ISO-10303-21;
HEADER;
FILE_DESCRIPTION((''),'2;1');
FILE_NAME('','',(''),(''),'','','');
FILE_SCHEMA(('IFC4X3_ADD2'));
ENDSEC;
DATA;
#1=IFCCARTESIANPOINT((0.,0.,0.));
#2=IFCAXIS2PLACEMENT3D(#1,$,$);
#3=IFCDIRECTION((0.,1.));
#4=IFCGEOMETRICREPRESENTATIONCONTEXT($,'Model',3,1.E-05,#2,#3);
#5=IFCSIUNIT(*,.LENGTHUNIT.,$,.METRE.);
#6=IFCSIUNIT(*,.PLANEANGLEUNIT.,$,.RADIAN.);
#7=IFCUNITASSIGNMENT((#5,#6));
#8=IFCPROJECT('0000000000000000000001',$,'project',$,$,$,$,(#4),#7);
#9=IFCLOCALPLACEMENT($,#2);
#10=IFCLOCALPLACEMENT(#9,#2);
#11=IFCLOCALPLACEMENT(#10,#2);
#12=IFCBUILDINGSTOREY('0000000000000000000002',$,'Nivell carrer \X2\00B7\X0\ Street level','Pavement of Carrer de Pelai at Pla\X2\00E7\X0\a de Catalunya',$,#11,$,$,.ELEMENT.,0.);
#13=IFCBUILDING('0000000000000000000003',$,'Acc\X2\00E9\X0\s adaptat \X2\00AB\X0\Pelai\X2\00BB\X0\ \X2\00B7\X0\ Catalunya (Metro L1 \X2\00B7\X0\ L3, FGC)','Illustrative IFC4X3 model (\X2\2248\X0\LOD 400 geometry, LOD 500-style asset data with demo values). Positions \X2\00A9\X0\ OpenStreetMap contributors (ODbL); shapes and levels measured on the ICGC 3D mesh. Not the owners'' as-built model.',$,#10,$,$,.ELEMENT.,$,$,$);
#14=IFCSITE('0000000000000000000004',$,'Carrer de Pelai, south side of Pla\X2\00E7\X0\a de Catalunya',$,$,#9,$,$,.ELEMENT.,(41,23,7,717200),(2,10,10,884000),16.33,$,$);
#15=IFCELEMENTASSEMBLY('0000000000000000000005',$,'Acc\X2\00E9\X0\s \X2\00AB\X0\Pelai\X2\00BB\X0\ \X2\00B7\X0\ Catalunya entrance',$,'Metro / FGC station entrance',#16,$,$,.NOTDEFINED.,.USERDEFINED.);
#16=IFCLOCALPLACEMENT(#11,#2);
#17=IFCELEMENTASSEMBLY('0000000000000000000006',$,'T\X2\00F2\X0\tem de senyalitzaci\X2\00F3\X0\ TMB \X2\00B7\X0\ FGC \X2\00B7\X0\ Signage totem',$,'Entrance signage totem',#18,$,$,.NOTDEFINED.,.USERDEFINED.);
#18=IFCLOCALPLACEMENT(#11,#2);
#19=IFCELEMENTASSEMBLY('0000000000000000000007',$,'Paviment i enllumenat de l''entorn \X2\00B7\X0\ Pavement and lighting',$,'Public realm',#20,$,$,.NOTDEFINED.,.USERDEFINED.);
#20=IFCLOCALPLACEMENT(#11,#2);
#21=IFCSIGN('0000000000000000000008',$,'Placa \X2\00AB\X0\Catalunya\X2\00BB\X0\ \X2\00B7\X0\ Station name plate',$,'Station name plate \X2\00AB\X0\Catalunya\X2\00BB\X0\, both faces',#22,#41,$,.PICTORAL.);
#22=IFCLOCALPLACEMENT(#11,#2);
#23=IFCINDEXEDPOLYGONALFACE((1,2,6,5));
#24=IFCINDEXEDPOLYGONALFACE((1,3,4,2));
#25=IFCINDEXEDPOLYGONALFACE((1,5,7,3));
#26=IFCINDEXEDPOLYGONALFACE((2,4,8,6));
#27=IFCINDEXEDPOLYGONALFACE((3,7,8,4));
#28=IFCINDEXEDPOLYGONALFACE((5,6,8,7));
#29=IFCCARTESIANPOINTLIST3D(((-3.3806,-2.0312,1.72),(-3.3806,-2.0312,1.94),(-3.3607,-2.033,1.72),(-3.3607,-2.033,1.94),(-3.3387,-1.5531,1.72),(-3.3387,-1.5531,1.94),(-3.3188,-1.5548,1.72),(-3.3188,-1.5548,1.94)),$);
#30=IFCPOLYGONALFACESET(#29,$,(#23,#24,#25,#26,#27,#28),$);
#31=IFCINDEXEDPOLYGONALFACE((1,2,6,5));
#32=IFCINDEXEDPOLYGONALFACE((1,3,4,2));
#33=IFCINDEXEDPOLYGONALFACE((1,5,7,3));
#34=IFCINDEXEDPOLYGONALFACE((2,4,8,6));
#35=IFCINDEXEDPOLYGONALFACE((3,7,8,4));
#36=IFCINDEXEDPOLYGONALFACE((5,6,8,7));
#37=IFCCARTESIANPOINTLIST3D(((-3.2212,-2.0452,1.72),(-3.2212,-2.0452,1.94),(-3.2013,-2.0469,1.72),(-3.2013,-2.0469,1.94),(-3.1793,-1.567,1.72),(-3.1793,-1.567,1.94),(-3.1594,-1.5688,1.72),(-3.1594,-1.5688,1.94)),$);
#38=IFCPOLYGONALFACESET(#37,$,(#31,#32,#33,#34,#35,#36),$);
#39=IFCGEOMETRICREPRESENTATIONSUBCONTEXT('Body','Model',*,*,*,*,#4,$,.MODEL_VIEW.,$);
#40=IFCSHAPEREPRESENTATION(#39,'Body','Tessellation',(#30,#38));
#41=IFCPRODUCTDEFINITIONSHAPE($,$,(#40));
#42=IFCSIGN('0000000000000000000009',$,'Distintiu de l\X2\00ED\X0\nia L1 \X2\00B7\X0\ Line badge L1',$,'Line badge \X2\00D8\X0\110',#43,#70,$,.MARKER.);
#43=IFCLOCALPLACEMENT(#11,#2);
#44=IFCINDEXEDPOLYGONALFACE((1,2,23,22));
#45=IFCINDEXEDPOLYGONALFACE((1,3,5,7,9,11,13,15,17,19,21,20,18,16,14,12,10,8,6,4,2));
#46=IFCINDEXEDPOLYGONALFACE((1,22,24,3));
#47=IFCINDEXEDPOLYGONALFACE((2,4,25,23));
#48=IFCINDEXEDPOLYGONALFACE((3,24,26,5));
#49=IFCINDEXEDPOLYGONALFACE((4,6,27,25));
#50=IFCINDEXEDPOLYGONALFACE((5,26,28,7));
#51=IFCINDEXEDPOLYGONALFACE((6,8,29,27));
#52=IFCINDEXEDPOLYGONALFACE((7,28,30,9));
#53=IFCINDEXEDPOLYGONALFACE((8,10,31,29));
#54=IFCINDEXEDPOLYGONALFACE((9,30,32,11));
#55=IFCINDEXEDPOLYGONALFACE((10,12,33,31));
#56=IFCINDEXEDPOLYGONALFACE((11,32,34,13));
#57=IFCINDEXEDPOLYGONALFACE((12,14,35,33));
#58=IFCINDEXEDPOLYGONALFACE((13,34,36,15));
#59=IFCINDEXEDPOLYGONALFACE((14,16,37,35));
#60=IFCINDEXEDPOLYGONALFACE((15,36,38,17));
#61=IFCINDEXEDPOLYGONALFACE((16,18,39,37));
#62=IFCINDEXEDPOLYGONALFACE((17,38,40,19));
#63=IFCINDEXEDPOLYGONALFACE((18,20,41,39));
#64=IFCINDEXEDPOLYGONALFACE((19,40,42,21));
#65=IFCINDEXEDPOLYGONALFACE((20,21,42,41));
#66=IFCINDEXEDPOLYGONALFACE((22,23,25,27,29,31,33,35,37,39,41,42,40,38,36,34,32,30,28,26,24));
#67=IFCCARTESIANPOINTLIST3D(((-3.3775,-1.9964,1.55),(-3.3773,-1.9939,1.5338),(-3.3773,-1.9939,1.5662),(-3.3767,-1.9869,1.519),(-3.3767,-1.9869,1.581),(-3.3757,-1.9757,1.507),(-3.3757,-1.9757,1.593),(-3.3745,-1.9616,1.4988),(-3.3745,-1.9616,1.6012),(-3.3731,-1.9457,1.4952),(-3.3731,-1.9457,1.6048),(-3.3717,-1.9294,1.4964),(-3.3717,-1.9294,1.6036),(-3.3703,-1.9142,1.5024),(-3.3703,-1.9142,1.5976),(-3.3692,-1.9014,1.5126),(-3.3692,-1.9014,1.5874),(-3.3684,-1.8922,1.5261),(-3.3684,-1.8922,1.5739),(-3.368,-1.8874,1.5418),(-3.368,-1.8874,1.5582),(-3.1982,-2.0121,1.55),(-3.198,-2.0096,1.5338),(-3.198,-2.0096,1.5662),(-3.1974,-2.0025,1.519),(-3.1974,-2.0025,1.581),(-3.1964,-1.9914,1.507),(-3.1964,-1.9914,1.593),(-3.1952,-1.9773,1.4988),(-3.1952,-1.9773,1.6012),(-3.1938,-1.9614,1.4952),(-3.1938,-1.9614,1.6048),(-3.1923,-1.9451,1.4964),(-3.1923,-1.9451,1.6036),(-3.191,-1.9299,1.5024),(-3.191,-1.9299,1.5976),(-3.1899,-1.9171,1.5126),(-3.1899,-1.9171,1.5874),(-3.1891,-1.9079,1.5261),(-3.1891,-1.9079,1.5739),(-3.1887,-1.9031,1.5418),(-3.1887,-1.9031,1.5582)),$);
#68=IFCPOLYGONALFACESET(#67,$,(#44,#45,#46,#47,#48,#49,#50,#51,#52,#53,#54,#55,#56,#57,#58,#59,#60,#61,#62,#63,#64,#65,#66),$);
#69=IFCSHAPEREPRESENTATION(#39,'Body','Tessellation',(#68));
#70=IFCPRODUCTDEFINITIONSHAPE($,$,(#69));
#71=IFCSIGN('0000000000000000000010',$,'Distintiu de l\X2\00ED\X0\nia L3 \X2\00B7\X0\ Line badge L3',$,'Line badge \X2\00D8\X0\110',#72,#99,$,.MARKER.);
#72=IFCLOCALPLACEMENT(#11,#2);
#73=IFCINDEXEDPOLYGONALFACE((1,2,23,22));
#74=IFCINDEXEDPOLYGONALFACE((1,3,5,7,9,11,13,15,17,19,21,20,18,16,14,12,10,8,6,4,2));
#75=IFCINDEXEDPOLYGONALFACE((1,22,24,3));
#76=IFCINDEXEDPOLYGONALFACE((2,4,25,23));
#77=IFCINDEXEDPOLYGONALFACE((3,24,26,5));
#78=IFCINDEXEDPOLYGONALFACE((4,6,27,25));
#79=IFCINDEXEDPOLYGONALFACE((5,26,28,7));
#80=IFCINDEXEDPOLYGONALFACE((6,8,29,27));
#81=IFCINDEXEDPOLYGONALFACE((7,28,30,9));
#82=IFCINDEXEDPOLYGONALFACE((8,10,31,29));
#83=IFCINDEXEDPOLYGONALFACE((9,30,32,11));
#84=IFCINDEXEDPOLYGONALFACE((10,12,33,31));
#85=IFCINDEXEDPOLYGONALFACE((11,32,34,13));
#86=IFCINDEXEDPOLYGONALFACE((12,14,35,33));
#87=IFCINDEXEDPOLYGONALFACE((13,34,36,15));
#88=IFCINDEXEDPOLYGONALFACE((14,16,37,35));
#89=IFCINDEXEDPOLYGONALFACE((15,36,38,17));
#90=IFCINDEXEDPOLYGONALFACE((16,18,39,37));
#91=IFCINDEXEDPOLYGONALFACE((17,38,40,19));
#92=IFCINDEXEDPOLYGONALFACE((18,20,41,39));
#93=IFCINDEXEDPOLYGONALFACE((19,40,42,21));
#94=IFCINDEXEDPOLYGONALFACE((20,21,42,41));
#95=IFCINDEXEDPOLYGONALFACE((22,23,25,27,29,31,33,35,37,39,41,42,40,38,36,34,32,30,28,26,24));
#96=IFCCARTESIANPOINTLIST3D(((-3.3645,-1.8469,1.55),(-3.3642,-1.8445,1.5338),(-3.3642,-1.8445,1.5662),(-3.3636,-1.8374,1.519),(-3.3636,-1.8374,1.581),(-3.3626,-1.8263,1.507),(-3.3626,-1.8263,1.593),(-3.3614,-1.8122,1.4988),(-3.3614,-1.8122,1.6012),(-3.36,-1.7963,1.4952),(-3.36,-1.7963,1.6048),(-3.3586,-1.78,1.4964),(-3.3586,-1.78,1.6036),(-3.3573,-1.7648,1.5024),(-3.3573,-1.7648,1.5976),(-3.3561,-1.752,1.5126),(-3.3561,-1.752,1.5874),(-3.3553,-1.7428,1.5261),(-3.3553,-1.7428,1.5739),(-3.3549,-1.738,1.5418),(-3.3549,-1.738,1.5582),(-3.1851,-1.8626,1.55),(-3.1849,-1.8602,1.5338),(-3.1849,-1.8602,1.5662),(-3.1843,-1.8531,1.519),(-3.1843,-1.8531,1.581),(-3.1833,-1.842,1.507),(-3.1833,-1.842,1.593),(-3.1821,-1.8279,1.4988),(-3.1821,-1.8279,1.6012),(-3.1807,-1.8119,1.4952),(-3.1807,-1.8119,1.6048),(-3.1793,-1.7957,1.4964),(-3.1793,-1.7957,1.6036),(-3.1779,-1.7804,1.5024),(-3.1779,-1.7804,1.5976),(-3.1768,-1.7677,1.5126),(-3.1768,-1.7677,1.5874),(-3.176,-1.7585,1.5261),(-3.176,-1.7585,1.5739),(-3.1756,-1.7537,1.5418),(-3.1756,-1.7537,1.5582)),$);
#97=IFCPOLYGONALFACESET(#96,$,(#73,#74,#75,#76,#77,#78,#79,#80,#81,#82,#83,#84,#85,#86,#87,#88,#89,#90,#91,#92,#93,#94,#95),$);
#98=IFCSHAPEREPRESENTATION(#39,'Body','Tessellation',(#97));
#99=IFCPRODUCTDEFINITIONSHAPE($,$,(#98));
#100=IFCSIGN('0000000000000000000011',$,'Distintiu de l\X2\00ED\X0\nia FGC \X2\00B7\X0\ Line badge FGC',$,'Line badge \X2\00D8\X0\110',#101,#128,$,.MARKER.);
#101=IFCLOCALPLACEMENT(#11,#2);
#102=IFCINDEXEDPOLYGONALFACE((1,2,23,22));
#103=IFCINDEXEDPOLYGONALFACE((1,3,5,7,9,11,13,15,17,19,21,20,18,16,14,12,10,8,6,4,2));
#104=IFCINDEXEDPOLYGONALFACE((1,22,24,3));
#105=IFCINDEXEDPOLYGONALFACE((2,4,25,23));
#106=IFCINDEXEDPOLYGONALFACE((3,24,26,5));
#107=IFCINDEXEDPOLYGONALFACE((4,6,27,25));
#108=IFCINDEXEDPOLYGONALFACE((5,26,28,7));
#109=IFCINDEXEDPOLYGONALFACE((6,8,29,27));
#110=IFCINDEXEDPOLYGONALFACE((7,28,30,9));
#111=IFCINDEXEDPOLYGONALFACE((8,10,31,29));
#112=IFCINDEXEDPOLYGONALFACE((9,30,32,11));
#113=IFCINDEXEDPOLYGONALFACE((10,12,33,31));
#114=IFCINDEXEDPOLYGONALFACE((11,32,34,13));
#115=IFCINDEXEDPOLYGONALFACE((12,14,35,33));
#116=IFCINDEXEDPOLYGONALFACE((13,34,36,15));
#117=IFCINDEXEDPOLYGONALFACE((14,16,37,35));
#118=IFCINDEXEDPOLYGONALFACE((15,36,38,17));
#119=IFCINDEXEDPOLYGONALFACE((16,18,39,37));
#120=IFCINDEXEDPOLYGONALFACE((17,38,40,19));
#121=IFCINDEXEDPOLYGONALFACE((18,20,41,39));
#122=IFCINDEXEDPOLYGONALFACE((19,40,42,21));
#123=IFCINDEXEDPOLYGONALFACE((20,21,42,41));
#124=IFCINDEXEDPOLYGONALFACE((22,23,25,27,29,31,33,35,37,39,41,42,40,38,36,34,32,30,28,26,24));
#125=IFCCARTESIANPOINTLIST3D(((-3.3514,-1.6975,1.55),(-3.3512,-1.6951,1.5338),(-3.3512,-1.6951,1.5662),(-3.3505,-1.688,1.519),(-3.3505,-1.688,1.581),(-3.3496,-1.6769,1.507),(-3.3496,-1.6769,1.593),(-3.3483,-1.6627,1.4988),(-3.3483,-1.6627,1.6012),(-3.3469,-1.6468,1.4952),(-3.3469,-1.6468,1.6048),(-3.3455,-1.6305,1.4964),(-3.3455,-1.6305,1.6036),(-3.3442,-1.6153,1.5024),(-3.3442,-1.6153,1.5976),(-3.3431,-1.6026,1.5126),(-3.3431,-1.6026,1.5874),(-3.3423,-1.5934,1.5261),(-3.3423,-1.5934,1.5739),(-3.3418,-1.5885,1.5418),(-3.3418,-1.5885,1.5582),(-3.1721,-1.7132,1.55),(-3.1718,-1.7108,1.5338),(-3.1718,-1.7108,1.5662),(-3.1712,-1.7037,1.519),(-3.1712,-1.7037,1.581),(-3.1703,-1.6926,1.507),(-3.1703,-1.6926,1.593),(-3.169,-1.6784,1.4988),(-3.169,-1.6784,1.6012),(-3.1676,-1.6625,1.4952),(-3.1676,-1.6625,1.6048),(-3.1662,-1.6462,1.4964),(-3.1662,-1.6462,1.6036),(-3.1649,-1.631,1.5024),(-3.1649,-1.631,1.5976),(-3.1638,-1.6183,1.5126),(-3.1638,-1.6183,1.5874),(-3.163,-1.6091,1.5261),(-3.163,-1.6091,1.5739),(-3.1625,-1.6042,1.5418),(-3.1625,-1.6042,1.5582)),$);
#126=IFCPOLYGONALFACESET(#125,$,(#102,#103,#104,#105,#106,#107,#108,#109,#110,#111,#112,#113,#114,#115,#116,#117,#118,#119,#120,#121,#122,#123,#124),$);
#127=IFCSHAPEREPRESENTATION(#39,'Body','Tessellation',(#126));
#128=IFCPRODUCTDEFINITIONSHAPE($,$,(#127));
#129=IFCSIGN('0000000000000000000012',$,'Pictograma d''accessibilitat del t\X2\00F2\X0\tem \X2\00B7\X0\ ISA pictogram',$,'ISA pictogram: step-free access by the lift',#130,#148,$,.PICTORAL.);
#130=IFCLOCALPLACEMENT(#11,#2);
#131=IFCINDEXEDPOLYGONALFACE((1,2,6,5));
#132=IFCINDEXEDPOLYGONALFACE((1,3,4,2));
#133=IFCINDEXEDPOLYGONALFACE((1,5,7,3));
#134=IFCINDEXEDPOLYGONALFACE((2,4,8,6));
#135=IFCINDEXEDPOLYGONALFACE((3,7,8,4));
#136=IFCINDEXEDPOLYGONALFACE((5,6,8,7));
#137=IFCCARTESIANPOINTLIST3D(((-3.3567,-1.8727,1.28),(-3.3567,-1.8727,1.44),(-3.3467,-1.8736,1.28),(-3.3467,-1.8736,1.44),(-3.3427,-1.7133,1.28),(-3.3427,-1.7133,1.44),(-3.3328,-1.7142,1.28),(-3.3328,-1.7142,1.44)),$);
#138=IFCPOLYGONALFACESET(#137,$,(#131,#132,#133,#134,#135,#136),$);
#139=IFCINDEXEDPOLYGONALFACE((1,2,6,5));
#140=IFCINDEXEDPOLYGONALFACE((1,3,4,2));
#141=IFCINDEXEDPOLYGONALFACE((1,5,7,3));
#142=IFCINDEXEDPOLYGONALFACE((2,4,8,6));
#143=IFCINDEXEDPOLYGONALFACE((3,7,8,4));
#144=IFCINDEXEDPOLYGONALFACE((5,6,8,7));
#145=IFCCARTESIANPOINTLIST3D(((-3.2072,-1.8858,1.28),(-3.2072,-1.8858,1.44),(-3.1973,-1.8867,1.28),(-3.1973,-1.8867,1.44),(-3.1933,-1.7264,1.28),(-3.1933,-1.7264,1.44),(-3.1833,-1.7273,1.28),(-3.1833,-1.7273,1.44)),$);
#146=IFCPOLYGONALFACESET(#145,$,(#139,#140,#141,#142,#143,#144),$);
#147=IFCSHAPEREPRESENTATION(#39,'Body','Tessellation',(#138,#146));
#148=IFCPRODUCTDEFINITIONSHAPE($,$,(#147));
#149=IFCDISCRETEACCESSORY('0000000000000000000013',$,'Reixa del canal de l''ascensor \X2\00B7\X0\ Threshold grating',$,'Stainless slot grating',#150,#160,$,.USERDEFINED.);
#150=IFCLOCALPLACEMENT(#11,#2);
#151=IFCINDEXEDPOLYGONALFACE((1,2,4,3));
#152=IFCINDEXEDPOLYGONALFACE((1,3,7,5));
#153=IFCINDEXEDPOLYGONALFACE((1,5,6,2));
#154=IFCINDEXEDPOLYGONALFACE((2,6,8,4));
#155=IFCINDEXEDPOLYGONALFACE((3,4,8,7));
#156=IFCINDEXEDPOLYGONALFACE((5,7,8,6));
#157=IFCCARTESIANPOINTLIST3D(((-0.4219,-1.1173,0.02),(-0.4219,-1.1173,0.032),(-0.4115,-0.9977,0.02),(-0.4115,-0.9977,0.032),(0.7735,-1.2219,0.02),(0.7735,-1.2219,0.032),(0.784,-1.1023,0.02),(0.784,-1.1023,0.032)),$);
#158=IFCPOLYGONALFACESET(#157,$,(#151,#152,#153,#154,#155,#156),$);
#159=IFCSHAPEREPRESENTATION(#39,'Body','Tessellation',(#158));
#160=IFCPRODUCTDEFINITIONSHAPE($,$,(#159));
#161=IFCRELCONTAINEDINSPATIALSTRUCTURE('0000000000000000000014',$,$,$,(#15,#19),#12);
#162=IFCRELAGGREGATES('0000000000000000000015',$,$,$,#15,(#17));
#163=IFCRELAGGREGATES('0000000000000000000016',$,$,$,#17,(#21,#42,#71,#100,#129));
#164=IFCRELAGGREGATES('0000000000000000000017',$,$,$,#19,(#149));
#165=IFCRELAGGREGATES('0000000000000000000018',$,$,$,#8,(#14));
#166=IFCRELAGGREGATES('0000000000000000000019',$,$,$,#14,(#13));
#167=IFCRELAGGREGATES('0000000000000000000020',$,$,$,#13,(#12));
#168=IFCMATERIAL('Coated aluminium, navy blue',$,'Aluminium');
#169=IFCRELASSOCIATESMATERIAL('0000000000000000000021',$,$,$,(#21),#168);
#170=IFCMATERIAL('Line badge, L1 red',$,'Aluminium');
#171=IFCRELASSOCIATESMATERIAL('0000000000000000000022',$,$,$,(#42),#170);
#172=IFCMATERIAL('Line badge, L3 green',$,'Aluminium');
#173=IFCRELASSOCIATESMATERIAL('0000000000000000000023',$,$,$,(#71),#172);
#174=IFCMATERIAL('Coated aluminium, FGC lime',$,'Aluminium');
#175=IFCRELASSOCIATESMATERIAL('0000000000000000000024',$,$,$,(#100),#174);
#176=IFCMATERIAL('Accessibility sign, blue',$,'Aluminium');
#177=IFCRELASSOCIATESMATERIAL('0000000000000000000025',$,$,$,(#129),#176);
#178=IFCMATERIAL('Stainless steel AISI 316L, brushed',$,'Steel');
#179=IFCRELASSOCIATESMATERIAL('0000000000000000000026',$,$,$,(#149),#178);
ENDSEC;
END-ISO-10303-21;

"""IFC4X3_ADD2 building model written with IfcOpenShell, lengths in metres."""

from ifc_helpers import new_model, si_unit, direction, frame, frame_2d, origin, origin_2d_with_axis, place, context, subcontext, project, spatial, polyline, rectangle, circle, outline, extrude, material, element, aggregate, save


model = new_model("IFC4X3_ADD2")

# Units and contexts
model_context = context("Model", 3, precision=1e-05, world=origin(), true_north=direction((0.0, 1.0)))
body_context = subcontext(model_context, "Body", "Model", "MODEL_VIEW")
ifc_project = project(units=[si_unit("LENGTHUNIT", "METRE"), si_unit("PLANEANGLEUNIT", "RADIAN")], contexts=[model_context])

# Site, building, storey
site_placement = place(None, origin())
site = spatial("IfcSite", under=ifc_project, at=site_placement, Name="Carrer de Pelai, south side of Plaça de Catalunya", CompositionType="ELEMENT", RefLatitude=(41, 23, 7, 717200), RefLongitude=(2, 10, 10, 884000), RefElevation=16.33)
building_placement = place(site_placement, origin())
building = spatial("IfcBuilding", under=site, at=building_placement, Name="Accés adaptat «Pelai» · Catalunya (Metro L1 · L3, FGC)", Description="Illustrative IFC4X3 model (≈LOD 400 geometry, LOD 500-style asset data with demo values). Positions © OpenStreetMap contributors (ODbL); shapes and levels measured on the ICGC 3D mesh. Not the owners' as-built model.", CompositionType="ELEMENT")
storey_placement = place(building_placement, origin())
storey = spatial("IfcBuildingStorey", under=building, at=storey_placement, Name="Nivell carrer · Street level", Description="Pavement of Carrer de Pelai at Plaça de Catalunya", CompositionType="ELEMENT", Elevation=0.0)

# Shared definitions
ifc_material_1 = material(Name="Stainless steel AISI 316L, brushed", Category="Steel")

# Element assemblies
assembly_1_placement = place(building_placement, origin())
assembly_1 = element("IfcElementAssembly", 1, at=assembly_1_placement, inside=storey, Name="Accés «Pelai» · Catalunya entrance", ObjectType="Metro / FGC station entrance", AssemblyPlace="NOTDEFINED", PredefinedType="USERDEFINED")
assembly_2_placement = place(building_placement, origin())
assembly_2 = element("IfcElementAssembly", 2, at=assembly_2_placement, Name="Tòtem de senyalització TMB · FGC · Signage totem", ObjectType="Entrance signage totem", AssemblyPlace="NOTDEFINED", PredefinedType="USERDEFINED")
aggregate(assembly_1, [assembly_2])

# Element assembly
assembly_3_placement = place(building_placement, origin())
assembly_3 = element("IfcElementAssembly", 3, at=assembly_3_placement, inside=storey, Name="Paviment i enllumenat de l'entorn · Pavement and lighting", ObjectType="Public realm", AssemblyPlace="NOTDEFINED", PredefinedType="USERDEFINED")

# Shared definitions
ifc_material_2 = material(Name="Coated aluminium, FGC lime", Category="Aluminium")
ifc_material_3 = material(Name="Accessibility sign, blue", Category="Aluminium")

# Signs
ifc_material_4 = material(Name="Coated aluminium, navy blue", Category="Aluminium")
sign_1_placement = place(building_placement, origin())
sign_1 = element("IfcSign", 4, at=sign_1_placement, material=ifc_material_4, Name="Placa «Catalunya» · Station name plate", ObjectType="Station name plate «Catalunya», both faces", PredefinedType="PICTORAL", context=body_context, shape_type="SweptSolid", body=[
    extrude(outline(polyline([(-0.24, 1.72), (0.24, 1.72), (0.24, 1.94), (-0.24, 1.94), (-0.24, 1.72)])), frame((-3.3597, -1.7922, 0.0), z_axis=(0.996195, -0.087156, 0.0), x_axis=(0.087156, 0.996195, 0.0)), (0.0, 0.0, 1.0), 0.02),
    extrude(outline(polyline([(-0.24, 1.72), (0.24, 1.72), (0.24, 1.94), (-0.24, 1.94), (-0.24, 1.72)])), frame((-3.2003, -1.8061, 0.0), z_axis=(0.996195, -0.087156, 0.0), x_axis=(0.087156, 0.996195, 0.0)), (0.0, 0.0, 1.0), 0.02),
])
ifc_material_5 = material(Name="Line badge, L1 red", Category="Aluminium")
sign_2_placement = place(building_placement, origin())
sign_2 = element("IfcSign", 5, at=sign_2_placement, material=ifc_material_5, Name="Distintiu de línia L1 · Line badge L1", ObjectType="Line badge Ø110", PredefinedType="MARKER", context=body_context, shape_type="SweptSolid", body=[
    extrude(circle(Radius=0.055, at=origin_2d_with_axis()), frame((-3.3727, -1.9416, 1.55), z_axis=(0.996195, -0.087156, 0.0), x_axis=(-0.087156, -0.996195, 0.0)), (0.0, 0.0, 1.0), 0.18),
])
ifc_material_6 = material(Name="Line badge, L3 green", Category="Aluminium")
sign_3_placement = place(building_placement, origin())
sign_3 = element("IfcSign", 6, at=sign_3_placement, material=ifc_material_6, Name="Distintiu de línia L3 · Line badge L3", ObjectType="Line badge Ø110", PredefinedType="MARKER", context=body_context, shape_type="SweptSolid", body=[
    extrude(circle(Radius=0.055, at=origin_2d_with_axis()), frame((-3.3597, -1.7922, 1.55), z_axis=(0.996195, -0.087156, 0.0), x_axis=(-0.087156, -0.996195, 0.0)), (0.0, 0.0, 1.0), 0.18),
])
sign_4_placement = place(building_placement, origin())
sign_4 = element("IfcSign", 7, at=sign_4_placement, material=ifc_material_2, Name="Distintiu de línia FGC · Line badge FGC", ObjectType="Line badge Ø110", PredefinedType="MARKER", context=body_context, shape_type="SweptSolid", body=[
    extrude(circle(Radius=0.055, at=origin_2d_with_axis()), frame((-3.3466, -1.6427, 1.55), z_axis=(0.996195, -0.087156, 0.0), x_axis=(-0.087156, -0.996195, 0.0)), (0.0, 0.0, 1.0), 0.18),
])
sign_5_placement = place(building_placement, origin())
sign_5 = element("IfcSign", 8, at=sign_5_placement, material=ifc_material_3, Name="Pictograma d'accessibilitat del tòtem · ISA pictogram", ObjectType="ISA pictogram: step-free access by the lift", PredefinedType="PICTORAL", context=body_context, shape_type="SweptSolid", body=[
    extrude(outline(polyline([(-0.08, 1.28), (0.08, 1.28), (0.08, 1.44), (-0.08, 1.44), (-0.08, 1.28)])), frame((-3.3497, -1.793, 0.0), z_axis=(0.996195, -0.087156, 0.0), x_axis=(0.087156, 0.996195, 0.0)), (0.0, 0.0, 1.0), 0.01),
    extrude(outline(polyline([(-0.08, 1.28), (0.08, 1.28), (0.08, 1.44), (-0.08, 1.44), (-0.08, 1.28)])), frame((-3.2003, -1.8061, 0.0), z_axis=(0.996195, -0.087156, 0.0), x_axis=(0.087156, 0.996195, 0.0)), (0.0, 0.0, 1.0), 0.01),
])
aggregate(assembly_2, [sign_1, sign_2, sign_3, sign_4, sign_5])

# Discrete accessory
discrete_accessory_1_placement = place(building_placement, origin())
discrete_accessory_1 = element("IfcDiscreteAccessory", 9, at=discrete_accessory_1_placement, material=ifc_material_1, Name="Reixa del canal de l'ascensor · Threshold grating", ObjectType="Stainless slot grating", PredefinedType="USERDEFINED", context=body_context, shape_type="SweptSolid", body=[
    extrude(rectangle(XDim=1.2, YDim=0.12, at=frame_2d((0.0, 0.0), x_axis=(0.996195, -0.087156))), frame((0.181, -1.1098, 0.02)), (0.0, 0.0, 1.0), 0.012),
])
aggregate(assembly_3, [discrete_accessory_1])

save(model, "model.ifc")
